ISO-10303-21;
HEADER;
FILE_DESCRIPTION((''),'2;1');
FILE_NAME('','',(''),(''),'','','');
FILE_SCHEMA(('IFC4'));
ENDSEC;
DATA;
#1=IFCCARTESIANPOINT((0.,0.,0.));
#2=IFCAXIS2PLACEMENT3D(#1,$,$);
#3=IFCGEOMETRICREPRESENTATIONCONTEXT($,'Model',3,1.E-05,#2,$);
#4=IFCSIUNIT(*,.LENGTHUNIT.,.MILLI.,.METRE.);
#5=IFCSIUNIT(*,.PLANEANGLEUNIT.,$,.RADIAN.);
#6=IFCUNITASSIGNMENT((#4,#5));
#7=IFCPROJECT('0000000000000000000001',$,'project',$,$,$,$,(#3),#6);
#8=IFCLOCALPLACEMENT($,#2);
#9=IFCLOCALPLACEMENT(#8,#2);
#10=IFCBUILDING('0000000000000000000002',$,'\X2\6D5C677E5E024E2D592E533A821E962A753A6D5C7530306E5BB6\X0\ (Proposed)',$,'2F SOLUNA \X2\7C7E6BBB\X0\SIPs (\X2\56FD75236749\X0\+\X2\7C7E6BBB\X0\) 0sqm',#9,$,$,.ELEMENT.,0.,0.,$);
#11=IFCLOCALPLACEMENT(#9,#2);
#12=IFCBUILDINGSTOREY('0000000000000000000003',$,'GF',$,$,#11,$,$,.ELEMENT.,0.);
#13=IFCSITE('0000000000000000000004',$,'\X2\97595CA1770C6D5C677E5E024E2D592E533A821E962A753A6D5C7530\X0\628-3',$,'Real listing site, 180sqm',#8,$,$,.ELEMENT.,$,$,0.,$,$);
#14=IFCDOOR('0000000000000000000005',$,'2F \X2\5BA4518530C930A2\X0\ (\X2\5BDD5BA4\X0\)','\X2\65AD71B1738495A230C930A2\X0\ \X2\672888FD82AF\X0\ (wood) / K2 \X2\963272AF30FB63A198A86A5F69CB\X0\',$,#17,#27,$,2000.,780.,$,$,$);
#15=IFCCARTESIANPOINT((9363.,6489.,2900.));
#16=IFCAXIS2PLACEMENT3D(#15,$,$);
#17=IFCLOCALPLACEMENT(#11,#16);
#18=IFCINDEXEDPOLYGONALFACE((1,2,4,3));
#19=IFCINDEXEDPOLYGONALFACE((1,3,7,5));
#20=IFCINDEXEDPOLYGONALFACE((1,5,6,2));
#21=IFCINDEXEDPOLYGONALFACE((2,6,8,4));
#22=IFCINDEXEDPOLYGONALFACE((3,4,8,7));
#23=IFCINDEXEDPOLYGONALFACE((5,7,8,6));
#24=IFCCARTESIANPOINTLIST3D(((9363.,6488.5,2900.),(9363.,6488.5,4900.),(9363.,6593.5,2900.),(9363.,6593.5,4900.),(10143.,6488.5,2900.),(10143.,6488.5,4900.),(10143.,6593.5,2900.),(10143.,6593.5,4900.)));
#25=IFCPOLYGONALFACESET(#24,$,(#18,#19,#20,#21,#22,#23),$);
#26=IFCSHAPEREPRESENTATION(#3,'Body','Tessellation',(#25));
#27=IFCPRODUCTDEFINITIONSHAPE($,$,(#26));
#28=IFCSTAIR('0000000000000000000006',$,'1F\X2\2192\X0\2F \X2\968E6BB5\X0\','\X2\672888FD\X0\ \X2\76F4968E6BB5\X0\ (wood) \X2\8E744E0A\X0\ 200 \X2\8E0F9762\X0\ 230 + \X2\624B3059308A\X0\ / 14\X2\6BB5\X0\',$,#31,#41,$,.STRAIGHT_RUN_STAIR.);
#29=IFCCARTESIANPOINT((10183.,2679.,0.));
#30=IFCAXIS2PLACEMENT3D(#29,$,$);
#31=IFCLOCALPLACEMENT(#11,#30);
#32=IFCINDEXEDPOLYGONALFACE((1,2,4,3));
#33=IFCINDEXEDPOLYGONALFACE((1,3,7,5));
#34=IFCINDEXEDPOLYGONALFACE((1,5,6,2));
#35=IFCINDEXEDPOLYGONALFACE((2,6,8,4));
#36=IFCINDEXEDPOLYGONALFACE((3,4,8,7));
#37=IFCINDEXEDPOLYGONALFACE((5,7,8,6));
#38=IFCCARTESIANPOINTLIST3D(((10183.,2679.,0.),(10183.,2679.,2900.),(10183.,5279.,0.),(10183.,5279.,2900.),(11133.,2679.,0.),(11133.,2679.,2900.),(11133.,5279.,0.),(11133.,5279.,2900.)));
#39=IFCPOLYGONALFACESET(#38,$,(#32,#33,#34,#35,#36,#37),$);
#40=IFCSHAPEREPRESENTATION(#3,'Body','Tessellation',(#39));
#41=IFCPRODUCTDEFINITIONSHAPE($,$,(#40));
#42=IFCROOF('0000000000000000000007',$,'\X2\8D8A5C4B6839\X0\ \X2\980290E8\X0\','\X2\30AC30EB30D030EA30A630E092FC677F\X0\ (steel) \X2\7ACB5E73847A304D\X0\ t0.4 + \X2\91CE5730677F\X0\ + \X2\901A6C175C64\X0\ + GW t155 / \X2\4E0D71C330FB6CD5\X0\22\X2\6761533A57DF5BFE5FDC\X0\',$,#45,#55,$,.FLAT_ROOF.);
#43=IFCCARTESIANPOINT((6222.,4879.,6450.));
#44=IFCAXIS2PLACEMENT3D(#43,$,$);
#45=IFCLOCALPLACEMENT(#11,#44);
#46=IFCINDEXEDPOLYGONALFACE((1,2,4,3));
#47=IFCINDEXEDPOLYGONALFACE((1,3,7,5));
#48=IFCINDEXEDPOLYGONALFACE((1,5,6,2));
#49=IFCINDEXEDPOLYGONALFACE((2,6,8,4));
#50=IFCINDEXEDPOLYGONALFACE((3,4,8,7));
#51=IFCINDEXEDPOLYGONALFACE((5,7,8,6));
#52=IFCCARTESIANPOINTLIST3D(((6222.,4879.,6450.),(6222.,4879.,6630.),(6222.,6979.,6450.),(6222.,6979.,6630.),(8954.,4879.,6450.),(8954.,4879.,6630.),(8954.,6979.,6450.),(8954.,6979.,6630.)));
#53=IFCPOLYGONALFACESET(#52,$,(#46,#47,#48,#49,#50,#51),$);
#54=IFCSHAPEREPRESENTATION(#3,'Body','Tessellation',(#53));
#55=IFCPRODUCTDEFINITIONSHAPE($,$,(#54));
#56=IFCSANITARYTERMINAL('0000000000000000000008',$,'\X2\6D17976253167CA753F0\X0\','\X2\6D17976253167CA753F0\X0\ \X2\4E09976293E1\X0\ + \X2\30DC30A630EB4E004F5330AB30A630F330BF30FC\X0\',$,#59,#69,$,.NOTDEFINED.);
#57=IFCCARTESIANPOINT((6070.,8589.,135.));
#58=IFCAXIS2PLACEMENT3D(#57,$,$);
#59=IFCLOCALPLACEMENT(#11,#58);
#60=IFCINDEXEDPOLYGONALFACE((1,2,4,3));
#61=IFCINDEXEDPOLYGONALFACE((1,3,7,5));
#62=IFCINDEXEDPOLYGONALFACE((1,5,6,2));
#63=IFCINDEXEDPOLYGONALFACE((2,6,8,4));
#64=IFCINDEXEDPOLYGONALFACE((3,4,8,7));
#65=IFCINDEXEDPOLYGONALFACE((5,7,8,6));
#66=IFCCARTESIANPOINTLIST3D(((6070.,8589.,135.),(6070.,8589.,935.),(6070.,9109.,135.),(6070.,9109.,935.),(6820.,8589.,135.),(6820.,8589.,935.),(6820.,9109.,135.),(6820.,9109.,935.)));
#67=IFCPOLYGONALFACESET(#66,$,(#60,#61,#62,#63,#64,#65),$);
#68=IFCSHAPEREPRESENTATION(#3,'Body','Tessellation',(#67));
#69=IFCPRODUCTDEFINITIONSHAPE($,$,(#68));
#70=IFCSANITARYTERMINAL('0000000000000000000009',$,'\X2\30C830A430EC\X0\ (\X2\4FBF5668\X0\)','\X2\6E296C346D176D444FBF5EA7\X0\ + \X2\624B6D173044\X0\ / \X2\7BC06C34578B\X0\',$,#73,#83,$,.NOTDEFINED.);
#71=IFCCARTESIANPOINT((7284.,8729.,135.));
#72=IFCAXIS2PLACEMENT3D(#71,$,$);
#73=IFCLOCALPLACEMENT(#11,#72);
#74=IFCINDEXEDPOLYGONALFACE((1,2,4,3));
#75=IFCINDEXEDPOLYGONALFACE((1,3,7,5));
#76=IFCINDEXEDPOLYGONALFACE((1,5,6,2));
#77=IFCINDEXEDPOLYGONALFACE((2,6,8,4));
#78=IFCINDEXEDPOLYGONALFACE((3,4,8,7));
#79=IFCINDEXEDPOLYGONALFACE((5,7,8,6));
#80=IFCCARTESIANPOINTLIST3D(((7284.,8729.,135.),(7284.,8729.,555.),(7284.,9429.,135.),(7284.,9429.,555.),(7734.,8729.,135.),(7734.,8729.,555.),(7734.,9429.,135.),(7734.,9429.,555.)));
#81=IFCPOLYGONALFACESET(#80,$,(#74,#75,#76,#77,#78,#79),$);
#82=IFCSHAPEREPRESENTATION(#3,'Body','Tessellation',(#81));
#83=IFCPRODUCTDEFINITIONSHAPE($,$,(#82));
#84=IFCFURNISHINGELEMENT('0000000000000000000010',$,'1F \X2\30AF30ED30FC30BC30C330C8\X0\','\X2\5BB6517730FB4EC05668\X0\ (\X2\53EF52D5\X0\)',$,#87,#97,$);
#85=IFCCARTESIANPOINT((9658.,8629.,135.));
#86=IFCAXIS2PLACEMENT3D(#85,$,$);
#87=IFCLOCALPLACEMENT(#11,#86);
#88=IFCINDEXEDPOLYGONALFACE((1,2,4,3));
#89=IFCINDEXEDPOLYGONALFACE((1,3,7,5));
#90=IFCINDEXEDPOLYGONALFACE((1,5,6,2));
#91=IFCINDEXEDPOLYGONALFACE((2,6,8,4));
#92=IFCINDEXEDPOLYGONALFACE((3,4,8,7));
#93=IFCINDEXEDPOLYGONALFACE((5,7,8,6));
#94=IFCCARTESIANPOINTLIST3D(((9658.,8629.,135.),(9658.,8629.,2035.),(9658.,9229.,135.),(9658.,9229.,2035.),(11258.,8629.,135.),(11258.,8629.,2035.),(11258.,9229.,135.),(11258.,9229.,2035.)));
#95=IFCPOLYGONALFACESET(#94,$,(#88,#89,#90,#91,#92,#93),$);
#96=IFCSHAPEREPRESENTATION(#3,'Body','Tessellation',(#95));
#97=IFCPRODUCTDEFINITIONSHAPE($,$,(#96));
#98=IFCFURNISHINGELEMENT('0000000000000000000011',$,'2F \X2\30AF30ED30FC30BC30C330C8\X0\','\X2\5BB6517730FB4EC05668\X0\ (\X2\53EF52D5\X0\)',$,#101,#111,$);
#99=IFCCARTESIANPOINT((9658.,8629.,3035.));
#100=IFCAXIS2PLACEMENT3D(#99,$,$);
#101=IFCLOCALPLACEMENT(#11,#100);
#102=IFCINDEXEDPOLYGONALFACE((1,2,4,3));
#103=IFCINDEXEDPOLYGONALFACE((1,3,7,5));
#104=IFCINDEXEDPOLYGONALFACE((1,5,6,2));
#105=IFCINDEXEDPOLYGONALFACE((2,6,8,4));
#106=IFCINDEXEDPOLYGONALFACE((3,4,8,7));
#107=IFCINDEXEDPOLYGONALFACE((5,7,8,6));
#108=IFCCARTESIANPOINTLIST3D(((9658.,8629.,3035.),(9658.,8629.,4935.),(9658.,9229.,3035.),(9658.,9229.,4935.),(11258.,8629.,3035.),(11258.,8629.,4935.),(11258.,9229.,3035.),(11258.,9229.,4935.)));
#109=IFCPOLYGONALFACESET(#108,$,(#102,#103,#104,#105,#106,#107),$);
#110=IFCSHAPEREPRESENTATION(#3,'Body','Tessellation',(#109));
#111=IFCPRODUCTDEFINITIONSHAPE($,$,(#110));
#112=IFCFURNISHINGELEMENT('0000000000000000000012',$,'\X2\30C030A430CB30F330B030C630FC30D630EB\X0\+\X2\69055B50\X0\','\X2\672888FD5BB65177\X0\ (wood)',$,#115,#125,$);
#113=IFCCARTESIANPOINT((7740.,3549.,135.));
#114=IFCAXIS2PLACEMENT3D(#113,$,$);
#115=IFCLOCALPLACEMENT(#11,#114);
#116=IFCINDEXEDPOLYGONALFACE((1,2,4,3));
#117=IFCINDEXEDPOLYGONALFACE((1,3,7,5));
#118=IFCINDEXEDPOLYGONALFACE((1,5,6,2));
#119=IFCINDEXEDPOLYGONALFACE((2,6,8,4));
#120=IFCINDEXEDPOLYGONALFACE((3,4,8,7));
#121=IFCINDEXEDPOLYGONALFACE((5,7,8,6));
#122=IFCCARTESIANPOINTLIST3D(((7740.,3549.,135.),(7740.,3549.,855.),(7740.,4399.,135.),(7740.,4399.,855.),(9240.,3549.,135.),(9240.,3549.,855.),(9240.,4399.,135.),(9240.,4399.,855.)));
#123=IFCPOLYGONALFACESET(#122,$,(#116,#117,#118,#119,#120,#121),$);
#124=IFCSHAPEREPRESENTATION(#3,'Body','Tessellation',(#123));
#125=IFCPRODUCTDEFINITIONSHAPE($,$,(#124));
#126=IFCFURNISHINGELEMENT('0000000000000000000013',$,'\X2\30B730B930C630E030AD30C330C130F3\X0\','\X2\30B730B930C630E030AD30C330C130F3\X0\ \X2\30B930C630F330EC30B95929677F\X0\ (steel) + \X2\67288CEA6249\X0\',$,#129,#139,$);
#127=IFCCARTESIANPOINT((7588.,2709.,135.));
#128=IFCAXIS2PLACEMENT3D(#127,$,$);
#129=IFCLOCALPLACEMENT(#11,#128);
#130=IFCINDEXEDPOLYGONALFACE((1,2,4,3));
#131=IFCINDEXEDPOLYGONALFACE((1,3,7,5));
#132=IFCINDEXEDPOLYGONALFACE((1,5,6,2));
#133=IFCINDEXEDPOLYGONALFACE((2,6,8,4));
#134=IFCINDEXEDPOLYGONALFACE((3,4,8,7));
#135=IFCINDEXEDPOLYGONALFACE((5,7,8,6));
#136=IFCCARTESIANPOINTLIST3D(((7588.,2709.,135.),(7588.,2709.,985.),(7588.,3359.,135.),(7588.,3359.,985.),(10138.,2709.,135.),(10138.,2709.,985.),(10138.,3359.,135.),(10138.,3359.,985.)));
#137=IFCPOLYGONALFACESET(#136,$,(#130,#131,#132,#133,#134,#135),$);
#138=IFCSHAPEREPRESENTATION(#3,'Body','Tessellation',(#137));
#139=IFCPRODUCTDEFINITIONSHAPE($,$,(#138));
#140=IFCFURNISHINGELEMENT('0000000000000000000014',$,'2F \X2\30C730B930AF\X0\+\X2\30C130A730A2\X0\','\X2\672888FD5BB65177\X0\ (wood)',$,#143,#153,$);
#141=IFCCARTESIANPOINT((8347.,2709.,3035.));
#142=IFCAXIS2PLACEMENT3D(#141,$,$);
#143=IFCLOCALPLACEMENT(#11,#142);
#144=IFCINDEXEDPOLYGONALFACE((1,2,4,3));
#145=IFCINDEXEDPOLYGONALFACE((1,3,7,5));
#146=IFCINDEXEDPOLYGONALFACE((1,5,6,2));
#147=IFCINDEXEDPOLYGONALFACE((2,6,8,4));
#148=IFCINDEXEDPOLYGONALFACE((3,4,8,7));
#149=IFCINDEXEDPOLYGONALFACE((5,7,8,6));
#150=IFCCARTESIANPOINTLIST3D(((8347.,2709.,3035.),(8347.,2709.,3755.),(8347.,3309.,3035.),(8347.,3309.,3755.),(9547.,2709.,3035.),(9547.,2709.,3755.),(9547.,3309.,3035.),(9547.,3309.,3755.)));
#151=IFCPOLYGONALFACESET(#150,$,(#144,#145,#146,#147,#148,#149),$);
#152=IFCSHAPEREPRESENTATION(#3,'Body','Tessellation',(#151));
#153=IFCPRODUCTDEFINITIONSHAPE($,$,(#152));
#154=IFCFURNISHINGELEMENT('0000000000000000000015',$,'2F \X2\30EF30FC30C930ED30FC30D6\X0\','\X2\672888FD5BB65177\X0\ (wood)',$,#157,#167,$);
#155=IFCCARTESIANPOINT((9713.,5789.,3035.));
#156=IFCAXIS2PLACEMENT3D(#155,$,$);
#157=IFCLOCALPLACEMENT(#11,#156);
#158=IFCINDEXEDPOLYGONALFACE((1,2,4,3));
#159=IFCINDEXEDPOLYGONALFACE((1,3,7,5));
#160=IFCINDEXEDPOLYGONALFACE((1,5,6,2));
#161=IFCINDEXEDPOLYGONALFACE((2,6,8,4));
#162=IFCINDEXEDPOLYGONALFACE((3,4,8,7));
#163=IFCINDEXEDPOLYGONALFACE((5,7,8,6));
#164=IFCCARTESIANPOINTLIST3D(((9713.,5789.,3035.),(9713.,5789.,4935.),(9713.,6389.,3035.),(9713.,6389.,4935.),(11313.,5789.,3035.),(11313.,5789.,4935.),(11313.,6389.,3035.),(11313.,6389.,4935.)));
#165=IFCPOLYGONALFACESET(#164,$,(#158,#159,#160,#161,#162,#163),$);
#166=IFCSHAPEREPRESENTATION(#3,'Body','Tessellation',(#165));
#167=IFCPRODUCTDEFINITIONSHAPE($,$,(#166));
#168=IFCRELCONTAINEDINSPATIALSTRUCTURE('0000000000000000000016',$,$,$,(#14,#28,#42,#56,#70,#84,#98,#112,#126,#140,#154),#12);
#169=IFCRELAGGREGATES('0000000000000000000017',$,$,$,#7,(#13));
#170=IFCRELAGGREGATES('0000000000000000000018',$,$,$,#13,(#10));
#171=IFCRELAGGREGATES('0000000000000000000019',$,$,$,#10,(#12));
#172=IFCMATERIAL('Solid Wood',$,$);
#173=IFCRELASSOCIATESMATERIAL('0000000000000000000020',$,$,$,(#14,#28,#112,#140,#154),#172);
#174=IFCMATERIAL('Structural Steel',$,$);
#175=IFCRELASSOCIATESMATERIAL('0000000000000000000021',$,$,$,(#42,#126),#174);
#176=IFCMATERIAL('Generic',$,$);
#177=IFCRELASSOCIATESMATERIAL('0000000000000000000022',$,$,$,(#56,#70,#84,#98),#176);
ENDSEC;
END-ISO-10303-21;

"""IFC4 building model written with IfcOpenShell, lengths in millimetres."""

from ifc_helpers import new_model, si_unit, frame, frame_2d, origin, place, context, project, spatial, rectangle, extrude, material, element, save


model = new_model("IFC4")

# Units and contexts
model_context = context("Model", 3, precision=1e-05, world=origin())
ifc_project = project(units=[si_unit("LENGTHUNIT", "METRE", prefix="MILLI"), si_unit("PLANEANGLEUNIT", "RADIAN")], contexts=[model_context])

# Site, building, storey
site_placement = place(None, origin())
site = spatial("IfcSite", under=ifc_project, at=site_placement, Name="静岡県浜松市中央区舞阪町浜田628-3", ObjectType="Real listing site, 180sqm", CompositionType="ELEMENT", RefElevation=0.0)
building_placement = place(site_placement, origin())
building = spatial("IfcBuilding", under=site, at=building_placement, Name="浜松市中央区舞阪町浜田の家 (Proposed)", ObjectType="2F SOLUNA 籾殻SIPs (国産杉+籾殻) 0sqm", CompositionType="ELEMENT", ElevationOfRefHeight=0.0, ElevationOfTerrain=0.0)
storey_placement = place(building_placement, origin())
storey = spatial("IfcBuildingStorey", under=building, at=storey_placement, Name="GF", CompositionType="ELEMENT", Elevation=0.0)

# Shared definitions
ifc_material_1 = material(Name="Solid Wood")

# Door
door_1_placement = place(storey_placement, frame((9363.0, 6489.0, 2900.0)))
element("IfcDoor", 1, at=door_1_placement, inside=storey, material=ifc_material_1, Name="2F 室内ドア (寝室)", Description="断熱玄関ドア 木製芯 (wood) / K2 防犯・採風機構", OverallHeight=2000.0, OverallWidth=780.0, context=model_context, shape_type="SweptSolid", body=[
    extrude(rectangle(XDim=780.0, YDim=105.0, at=frame_2d((390.0, 52.0))), frame((9363.0, 6489.0, 2900.0)), (0.0, 0.0, 1.0), 2000.0),
])

# Stair
stair_placement = place(storey_placement, frame((10183.0, 2679.0, 0.0)))
element("IfcStair", 2, at=stair_placement, inside=storey, material=ifc_material_1, Name="1F→2F 階段", Description="木製 直階段 (wood) 蹴上 200 踏面 230 + 手すり / 14段", PredefinedType="STRAIGHT_RUN_STAIR", context=model_context, shape_type="SweptSolid", body=[
    extrude(rectangle(XDim=950.0, YDim=2600.0, at=frame_2d((475.0, 1300.0))), frame((10183.0, 2679.0, 0.0)), (0.0, 0.0, 1.0), 2900.0),
])

# Roof
ifc_material_2 = material(Name="Structural Steel")
roof_placement = place(storey_placement, frame((6222.0, 4879.0, 6450.0)))
element("IfcRoof", 3, at=roof_placement, inside=storey, material=ifc_material_2, Name="越屋根 頂部", Description="ガルバリウム鋼板 (steel) 立平葺き t0.4 + 野地板 + 通気層 + GW t155 / 不燃・法22条区域対応", PredefinedType="FLAT_ROOF", context=model_context, shape_type="SweptSolid", body=[
    extrude(rectangle(XDim=2732.0, YDim=2100.0, at=frame_2d((1366.0, 1050.0))), frame((6222.0, 4879.0, 6450.0)), (0.0, 0.0, 1.0), 180.0),
])

# Sanitary terminals
ifc_material_3 = material(Name="Generic")
sanitary_terminal_1_placement = place(storey_placement, frame((6070.0, 8589.0, 135.0)))
element("IfcSanitaryTerminal", 4, at=sanitary_terminal_1_placement, inside=storey, material=ifc_material_3, Name="洗面化粧台", Description="洗面化粧台 三面鏡 + ボウル一体カウンター", PredefinedType="NOTDEFINED", context=model_context, shape_type="SweptSolid", body=[
    extrude(rectangle(XDim=750.0, YDim=520.0, at=frame_2d((375.0, 260.0))), frame((6070.0, 8589.0, 135.0)), (0.0, 0.0, 1.0), 800.0),
])
sanitary_terminal_2_placement = place(storey_placement, frame((7284.0, 8729.0, 135.0)))
element("IfcSanitaryTerminal", 5, at=sanitary_terminal_2_placement, inside=storey, material=ifc_material_3, Name="トイレ (便器)", Description="温水洗浄便座 + 手洗い / 節水型", PredefinedType="NOTDEFINED", context=model_context, shape_type="SweptSolid", body=[
    extrude(rectangle(XDim=450.0, YDim=700.0, at=frame_2d((225.0, 350.0))), frame((7284.0, 8729.0, 135.0)), (0.0, 0.0, 1.0), 420.0),
])

# Furnishing elements
furnishing_1_placement = place(storey_placement, frame((9658.0, 8629.0, 135.0)))
element("IfcFurnishingElement", 6, at=furnishing_1_placement, inside=storey, material=ifc_material_3, Name="1F クローゼット", Description="家具・什器 (可動)", context=model_context, shape_type="SweptSolid", body=[
    extrude(rectangle(XDim=1600.0, YDim=600.0, at=frame_2d((800.0, 300.0))), frame((9658.0, 8629.0, 135.0)), (0.0, 0.0, 1.0), 1900.0),
])
furnishing_2_placement = place(storey_placement, frame((9658.0, 8629.0, 3035.0)))
element("IfcFurnishingElement", 7, at=furnishing_2_placement, inside=storey, material=ifc_material_3, Name="2F クローゼット", Description="家具・什器 (可動)", context=model_context, shape_type="SweptSolid", body=[
    extrude(rectangle(XDim=1600.0, YDim=600.0, at=frame_2d((800.0, 300.0))), frame((9658.0, 8629.0, 3035.0)), (0.0, 0.0, 1.0), 1900.0),
])
furnishing_3_placement = place(storey_placement, frame((7740.0, 3549.0, 135.0)))
element("IfcFurnishingElement", 8, at=furnishing_3_placement, inside=storey, material=ifc_material_1, Name="ダイニングテーブル+椅子", Description="木製家具 (wood)", context=model_context, shape_type="SweptSolid", body=[
    extrude(rectangle(XDim=1500.0, YDim=850.0, at=frame_2d((750.0, 425.0))), frame((7740.0, 3549.0, 135.0)), (0.0, 0.0, 1.0), 720.0),
])
furnishing_4_placement = place(storey_placement, frame((7588.0, 2709.0, 135.0)))
element("IfcFurnishingElement", 9, at=furnishing_4_placement, inside=storey, material=ifc_material_2, Name="システムキッチン", Description="システムキッチン ステンレス天板 (steel) + 木質扉", context=model_context, shape_type="SweptSolid", body=[
    extrude(rectangle(XDim=2550.0, YDim=650.0, at=frame_2d((1275.0, 325.0))), frame((7588.0, 2709.0, 135.0)), (0.0, 0.0, 1.0), 850.0),
])
furnishing_5_placement = place(storey_placement, frame((8347.0, 2709.0, 3035.0)))
element("IfcFurnishingElement", 10, at=furnishing_5_placement, inside=storey, material=ifc_material_1, Name="2F デスク+チェア", Description="木製家具 (wood)", context=model_context, shape_type="SweptSolid", body=[
    extrude(rectangle(XDim=1200.0, YDim=600.0, at=frame_2d((600.0, 300.0))), frame((8347.0, 2709.0, 3035.0)), (0.0, 0.0, 1.0), 720.0),
])
furnishing_6_placement = place(storey_placement, frame((9713.0, 5789.0, 3035.0)))
element("IfcFurnishingElement", 11, at=furnishing_6_placement, inside=storey, material=ifc_material_1, Name="2F ワードローブ", Description="木製家具 (wood)", context=model_context, shape_type="SweptSolid", body=[
    extrude(rectangle(XDim=1600.0, YDim=600.0, at=frame_2d((800.0, 300.0))), frame((9713.0, 5789.0, 3035.0)), (0.0, 0.0, 1.0), 1900.0),
])

save(model, "model.ifc")
